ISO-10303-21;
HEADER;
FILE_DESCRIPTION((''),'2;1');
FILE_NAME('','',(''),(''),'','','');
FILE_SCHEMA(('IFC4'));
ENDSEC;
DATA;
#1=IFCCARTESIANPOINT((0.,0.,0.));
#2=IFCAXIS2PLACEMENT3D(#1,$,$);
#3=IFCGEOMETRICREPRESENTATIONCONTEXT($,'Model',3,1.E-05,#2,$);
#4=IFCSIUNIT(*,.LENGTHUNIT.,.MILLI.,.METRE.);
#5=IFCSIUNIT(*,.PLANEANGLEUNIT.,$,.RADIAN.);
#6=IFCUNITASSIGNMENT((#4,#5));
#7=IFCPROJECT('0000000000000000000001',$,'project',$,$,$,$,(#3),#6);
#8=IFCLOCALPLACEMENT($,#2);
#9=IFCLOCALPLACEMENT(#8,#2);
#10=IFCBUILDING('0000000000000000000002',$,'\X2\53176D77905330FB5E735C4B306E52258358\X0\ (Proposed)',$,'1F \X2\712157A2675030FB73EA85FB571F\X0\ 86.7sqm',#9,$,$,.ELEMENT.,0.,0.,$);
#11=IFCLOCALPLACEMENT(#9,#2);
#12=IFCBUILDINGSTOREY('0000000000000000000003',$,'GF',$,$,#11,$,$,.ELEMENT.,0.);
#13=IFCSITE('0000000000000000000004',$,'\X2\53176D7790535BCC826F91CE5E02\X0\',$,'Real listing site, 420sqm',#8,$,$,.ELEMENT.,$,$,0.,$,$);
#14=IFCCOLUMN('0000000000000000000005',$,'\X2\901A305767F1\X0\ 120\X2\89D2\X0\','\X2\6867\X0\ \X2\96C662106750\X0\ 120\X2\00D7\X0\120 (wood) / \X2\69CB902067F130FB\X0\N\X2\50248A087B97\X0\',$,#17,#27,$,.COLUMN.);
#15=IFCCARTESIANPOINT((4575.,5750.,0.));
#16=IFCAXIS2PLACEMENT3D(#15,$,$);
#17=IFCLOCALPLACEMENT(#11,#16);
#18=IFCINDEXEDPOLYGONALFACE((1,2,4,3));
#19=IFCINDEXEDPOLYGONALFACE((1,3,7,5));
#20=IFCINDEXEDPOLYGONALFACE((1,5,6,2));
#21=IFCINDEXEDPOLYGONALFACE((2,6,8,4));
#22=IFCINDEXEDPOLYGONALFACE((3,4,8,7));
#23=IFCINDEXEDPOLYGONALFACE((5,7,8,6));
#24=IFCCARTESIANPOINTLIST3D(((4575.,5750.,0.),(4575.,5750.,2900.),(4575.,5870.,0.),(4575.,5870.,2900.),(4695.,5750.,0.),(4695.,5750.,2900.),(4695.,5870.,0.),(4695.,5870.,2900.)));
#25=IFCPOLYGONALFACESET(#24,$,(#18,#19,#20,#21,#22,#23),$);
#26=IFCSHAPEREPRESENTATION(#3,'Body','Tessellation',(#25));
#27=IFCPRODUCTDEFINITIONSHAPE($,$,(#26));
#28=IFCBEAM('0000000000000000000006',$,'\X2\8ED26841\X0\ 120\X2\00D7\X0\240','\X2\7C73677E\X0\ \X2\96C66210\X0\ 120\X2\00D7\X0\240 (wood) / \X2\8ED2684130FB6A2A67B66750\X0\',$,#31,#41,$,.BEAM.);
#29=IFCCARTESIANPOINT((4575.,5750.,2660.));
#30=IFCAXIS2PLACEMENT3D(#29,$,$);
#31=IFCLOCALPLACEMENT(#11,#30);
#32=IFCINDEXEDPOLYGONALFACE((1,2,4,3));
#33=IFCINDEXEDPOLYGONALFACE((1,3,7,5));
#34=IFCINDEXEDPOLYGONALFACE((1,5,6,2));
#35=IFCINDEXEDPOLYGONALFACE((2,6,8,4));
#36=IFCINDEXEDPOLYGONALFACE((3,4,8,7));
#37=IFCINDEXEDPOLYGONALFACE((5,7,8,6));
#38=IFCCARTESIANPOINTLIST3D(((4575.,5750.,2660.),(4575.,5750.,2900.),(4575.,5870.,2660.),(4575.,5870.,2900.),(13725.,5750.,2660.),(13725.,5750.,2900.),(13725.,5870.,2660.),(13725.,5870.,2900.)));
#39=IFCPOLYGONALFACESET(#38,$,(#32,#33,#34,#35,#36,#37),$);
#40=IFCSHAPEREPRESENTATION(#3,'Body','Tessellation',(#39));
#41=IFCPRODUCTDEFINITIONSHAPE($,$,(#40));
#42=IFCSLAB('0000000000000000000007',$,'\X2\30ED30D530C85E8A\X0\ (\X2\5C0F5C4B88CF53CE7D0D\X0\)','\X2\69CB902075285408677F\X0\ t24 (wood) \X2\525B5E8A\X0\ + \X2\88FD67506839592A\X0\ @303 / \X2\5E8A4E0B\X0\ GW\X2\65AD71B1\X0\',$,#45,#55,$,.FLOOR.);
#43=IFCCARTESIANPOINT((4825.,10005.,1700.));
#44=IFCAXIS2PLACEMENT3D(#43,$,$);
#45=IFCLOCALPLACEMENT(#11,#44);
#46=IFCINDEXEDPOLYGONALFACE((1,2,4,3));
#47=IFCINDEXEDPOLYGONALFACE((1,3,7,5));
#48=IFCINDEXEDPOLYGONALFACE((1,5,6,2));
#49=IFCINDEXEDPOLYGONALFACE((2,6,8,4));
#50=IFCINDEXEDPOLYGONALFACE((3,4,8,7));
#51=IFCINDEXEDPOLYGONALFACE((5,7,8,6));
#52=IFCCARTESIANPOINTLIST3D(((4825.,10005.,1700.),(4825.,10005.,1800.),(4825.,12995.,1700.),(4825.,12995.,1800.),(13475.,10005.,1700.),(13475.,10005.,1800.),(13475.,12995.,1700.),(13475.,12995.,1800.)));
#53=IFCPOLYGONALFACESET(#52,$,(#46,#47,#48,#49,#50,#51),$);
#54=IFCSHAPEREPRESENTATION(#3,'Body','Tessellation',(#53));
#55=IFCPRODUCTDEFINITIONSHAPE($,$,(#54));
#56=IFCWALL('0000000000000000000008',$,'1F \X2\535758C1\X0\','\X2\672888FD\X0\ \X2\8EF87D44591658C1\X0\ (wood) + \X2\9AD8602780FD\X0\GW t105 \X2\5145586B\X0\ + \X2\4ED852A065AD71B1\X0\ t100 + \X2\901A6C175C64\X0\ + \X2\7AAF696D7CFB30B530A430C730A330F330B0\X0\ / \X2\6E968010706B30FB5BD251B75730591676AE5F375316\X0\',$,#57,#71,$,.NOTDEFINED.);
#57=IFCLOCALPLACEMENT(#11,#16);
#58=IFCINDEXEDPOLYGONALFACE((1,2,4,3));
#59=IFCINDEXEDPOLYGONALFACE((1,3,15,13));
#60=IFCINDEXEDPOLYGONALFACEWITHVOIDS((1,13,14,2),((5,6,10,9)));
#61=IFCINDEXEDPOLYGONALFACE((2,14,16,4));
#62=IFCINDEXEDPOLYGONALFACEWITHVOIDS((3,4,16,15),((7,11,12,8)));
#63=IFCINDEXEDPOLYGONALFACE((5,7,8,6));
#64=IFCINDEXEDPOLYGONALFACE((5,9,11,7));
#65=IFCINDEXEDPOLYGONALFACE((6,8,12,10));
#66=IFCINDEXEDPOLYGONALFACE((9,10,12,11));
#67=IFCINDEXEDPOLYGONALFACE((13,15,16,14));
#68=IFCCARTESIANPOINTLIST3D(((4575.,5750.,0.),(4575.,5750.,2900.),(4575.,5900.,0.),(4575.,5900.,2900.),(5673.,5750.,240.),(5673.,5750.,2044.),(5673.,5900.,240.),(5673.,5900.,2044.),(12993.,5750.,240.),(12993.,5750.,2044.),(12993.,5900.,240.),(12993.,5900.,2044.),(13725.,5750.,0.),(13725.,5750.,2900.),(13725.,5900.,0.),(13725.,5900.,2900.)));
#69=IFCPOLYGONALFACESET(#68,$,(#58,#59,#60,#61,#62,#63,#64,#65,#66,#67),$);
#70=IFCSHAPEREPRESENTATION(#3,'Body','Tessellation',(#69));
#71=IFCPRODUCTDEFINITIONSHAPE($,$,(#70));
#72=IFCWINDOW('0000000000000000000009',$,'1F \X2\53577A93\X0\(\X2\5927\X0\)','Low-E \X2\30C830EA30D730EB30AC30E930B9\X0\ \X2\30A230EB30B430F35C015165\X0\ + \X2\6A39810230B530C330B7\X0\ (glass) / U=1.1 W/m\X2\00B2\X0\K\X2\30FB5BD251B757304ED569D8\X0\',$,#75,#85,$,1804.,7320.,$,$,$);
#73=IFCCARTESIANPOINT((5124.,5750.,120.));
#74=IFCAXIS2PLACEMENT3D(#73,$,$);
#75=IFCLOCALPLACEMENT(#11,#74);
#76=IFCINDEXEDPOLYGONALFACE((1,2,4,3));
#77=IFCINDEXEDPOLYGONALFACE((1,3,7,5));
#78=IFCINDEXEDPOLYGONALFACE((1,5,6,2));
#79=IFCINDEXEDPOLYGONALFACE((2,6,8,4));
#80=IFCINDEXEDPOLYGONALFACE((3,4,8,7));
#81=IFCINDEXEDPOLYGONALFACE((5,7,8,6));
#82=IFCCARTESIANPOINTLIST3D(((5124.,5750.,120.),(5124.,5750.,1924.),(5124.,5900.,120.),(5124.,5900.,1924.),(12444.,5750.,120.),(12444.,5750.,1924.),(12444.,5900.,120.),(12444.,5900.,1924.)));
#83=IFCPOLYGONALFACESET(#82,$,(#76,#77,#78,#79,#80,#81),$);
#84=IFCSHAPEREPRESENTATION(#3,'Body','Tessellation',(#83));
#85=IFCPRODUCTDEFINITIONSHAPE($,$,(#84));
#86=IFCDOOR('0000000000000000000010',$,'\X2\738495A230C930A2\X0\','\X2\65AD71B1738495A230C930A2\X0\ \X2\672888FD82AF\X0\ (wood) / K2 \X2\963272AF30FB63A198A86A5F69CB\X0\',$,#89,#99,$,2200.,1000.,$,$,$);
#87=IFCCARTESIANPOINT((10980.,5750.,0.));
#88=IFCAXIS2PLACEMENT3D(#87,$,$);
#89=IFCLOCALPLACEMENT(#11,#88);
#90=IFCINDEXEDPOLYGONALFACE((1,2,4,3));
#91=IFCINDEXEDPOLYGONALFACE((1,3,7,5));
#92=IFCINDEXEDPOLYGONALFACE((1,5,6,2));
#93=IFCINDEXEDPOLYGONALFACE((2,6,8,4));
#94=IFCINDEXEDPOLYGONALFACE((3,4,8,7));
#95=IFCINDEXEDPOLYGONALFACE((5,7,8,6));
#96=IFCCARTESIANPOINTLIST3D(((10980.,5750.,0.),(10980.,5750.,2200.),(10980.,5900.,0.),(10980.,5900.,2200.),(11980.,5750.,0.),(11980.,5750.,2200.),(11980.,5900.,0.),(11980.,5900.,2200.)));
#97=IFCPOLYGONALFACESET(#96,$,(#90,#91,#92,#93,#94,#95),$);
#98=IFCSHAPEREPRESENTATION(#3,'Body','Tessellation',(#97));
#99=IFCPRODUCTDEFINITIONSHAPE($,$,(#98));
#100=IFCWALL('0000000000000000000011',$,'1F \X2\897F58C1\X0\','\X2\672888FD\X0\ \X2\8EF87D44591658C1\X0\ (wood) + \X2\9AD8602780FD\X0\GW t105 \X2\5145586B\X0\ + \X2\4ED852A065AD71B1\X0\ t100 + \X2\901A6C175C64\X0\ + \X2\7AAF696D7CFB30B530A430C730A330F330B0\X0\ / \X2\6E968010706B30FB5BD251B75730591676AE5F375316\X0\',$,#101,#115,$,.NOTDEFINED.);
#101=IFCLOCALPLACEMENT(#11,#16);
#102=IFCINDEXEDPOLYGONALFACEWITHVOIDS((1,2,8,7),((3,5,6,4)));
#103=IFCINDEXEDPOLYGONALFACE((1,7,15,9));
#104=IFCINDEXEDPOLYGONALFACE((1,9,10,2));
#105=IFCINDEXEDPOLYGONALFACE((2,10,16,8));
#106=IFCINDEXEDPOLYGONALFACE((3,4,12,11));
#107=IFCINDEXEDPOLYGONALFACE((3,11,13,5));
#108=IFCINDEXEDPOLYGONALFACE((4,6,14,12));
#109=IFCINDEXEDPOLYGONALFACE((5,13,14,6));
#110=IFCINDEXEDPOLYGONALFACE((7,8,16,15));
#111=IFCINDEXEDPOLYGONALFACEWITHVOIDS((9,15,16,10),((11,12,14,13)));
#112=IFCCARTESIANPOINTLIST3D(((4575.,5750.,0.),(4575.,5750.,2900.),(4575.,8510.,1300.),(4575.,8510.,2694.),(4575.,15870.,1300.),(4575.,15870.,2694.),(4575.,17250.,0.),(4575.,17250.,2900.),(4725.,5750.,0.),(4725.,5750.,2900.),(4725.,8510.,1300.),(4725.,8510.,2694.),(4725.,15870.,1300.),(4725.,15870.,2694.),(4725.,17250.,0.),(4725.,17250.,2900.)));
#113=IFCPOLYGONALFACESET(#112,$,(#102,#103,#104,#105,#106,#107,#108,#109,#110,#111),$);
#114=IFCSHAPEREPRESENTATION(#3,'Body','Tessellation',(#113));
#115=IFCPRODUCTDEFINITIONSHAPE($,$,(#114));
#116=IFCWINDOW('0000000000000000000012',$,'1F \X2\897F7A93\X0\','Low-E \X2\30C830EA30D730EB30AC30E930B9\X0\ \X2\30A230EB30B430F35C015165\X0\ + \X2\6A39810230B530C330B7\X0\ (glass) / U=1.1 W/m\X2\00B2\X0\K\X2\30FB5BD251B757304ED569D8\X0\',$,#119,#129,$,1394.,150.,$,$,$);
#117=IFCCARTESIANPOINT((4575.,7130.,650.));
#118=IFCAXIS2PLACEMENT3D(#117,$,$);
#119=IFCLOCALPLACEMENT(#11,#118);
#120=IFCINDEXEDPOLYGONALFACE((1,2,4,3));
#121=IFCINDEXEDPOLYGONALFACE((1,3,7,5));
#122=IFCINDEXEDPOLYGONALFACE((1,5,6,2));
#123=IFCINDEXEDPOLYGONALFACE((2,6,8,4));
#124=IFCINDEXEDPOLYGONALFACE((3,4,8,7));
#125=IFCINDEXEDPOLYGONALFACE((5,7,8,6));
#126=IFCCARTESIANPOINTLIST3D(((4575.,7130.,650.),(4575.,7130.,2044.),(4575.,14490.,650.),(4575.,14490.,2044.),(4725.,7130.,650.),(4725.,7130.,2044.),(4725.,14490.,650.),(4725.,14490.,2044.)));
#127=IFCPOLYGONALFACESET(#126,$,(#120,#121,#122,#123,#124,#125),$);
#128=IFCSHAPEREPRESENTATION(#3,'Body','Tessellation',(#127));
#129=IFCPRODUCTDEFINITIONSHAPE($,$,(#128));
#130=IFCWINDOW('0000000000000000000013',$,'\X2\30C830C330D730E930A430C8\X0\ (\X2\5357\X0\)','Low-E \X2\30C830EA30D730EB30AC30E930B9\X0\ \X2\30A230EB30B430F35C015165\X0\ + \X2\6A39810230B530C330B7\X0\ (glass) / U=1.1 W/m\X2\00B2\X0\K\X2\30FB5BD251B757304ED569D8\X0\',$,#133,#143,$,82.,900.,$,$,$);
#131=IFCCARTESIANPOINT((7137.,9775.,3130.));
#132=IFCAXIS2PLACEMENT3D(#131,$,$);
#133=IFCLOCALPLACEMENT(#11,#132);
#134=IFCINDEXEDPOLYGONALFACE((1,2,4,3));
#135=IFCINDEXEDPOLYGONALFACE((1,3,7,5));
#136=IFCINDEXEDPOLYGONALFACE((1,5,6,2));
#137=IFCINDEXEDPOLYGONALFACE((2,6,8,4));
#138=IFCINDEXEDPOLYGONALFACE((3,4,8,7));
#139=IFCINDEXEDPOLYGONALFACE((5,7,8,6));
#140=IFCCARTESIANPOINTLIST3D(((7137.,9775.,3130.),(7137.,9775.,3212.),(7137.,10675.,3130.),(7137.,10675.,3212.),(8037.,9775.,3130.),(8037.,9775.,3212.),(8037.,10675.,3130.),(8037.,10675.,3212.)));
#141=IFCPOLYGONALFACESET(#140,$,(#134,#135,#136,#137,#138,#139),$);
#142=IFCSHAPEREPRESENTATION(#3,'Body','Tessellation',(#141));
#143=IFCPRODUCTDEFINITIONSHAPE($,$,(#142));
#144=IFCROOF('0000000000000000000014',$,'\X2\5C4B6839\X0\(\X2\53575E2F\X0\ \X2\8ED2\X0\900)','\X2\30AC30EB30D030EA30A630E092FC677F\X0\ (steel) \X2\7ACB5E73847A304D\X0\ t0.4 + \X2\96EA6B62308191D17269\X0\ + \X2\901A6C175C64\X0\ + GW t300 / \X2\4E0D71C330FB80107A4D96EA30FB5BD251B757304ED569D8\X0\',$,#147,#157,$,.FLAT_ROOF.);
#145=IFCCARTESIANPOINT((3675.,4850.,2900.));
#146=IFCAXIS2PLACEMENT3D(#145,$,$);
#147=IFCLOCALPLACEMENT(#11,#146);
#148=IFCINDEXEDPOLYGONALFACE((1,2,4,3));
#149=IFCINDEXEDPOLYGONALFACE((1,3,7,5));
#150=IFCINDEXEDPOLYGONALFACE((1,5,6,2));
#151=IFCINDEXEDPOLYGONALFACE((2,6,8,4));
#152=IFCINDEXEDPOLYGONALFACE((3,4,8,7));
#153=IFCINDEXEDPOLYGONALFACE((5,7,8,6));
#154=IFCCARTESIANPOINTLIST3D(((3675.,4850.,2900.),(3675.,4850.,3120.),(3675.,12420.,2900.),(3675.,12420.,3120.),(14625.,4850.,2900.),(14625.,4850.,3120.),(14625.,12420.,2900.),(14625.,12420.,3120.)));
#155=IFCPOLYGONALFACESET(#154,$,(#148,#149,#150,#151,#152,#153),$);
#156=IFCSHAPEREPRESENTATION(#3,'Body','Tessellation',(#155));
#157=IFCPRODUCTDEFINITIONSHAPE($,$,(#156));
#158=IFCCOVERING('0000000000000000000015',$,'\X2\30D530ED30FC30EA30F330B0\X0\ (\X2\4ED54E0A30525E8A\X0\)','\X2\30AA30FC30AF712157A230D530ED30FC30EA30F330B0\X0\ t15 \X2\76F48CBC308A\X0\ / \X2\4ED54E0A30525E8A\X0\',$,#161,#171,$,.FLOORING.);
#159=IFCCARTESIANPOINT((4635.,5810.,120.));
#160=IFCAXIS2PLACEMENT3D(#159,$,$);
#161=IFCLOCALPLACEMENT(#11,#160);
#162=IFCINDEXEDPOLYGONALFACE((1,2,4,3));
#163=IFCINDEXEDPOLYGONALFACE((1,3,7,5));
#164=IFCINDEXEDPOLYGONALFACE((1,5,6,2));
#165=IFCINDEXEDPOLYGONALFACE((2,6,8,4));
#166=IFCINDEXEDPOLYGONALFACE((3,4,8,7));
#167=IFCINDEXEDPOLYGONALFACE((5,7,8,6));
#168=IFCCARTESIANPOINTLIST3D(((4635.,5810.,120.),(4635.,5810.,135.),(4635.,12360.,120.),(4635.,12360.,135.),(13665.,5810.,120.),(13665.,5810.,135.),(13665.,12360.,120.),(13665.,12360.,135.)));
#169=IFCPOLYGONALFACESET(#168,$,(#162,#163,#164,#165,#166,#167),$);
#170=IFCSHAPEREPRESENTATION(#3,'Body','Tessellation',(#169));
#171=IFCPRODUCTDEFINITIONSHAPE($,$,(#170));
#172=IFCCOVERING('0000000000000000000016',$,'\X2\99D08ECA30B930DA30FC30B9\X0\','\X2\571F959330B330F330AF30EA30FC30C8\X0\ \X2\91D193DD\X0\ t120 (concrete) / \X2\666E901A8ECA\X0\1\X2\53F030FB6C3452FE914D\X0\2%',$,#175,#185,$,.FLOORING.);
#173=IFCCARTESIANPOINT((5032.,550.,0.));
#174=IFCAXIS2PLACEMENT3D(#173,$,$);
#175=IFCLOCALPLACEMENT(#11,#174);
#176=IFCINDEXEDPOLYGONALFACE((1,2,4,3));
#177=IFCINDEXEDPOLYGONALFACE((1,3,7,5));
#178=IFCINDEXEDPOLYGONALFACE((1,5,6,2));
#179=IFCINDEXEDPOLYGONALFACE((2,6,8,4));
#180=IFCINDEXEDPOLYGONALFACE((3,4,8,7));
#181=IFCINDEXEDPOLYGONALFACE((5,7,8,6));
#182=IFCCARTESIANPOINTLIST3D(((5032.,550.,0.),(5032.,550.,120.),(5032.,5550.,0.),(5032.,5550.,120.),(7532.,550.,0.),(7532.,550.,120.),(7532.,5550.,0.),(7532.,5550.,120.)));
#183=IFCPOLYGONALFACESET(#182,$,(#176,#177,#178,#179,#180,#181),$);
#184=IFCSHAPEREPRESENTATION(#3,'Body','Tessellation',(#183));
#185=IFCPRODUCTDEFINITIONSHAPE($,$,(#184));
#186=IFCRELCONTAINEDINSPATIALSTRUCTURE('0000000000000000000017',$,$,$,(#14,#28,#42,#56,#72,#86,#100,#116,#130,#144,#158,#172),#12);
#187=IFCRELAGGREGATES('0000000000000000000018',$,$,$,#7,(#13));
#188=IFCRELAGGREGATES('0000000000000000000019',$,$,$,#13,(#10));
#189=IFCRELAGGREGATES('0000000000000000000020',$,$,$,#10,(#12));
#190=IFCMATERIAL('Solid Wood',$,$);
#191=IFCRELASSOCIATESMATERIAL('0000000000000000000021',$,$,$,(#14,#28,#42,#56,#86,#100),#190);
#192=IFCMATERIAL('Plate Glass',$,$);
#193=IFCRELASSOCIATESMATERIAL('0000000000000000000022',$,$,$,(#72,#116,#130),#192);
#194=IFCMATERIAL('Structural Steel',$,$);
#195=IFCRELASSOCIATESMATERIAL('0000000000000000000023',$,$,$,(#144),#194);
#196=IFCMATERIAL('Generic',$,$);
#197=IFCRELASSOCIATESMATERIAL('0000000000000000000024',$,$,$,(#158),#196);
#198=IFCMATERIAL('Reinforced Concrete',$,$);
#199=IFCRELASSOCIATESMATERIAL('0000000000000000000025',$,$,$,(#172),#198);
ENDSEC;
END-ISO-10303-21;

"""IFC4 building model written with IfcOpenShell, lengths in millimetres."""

from ifc_helpers import new_model, si_unit, frame, frame_2d, origin, place, context, project, spatial, rectangle, extrude, material, element, fill, save


model = new_model("IFC4")

# Units and contexts
model_context = context("Model", 3, precision=1e-05, world=origin())
ifc_project = project(units=[si_unit("LENGTHUNIT", "METRE", prefix="MILLI"), si_unit("PLANEANGLEUNIT", "RADIAN")], contexts=[model_context])

# Site, building, storey
site_placement = place(None, origin())
site = spatial("IfcSite", under=ifc_project, at=site_placement, Name="北海道富良野市", ObjectType="Real listing site, 420sqm", CompositionType="ELEMENT", RefElevation=0.0)
building_placement = place(site_placement, origin())
building = spatial("IfcBuilding", under=site, at=building_placement, Name="北海道・平屋の別荘 (Proposed)", ObjectType="1F 無垢材・珪藻土 86.7sqm", CompositionType="ELEMENT", ElevationOfRefHeight=0.0, ElevationOfTerrain=0.0)
storey_placement = place(building_placement, origin())
storey = spatial("IfcBuildingStorey", under=building, at=storey_placement, Name="GF", CompositionType="ELEMENT", Elevation=0.0)

# Column
ifc_material_1 = material(Name="Solid Wood")
column_1_placement = place(storey_placement, frame((4575.0, 5750.0, 0.0)))
element("IfcColumn", 1, at=column_1_placement, inside=storey, material=ifc_material_1, Name="通し柱 120角", Description="桧 集成材 120×120 (wood) / 構造柱・N値計算", PredefinedType="COLUMN", context=model_context, shape_type="SweptSolid", body=[
    extrude(rectangle(XDim=120.0, YDim=120.0, at=frame_2d((60.0, 60.0))), frame((4575.0, 5750.0, 0.0)), (0.0, 0.0, 1.0), 2900.0),
])

# Beam
beam_1_placement = place(storey_placement, frame((4575.0, 5750.0, 2660.0)))
element("IfcBeam", 2, at=beam_1_placement, inside=storey, material=ifc_material_1, Name="軒桁 120×240", Description="米松 集成 120×240 (wood) / 軒桁・横架材", PredefinedType="BEAM", context=model_context, shape_type="SweptSolid", body=[
    extrude(rectangle(XDim=9150.0, YDim=120.0, at=frame_2d((4575.0, 60.0))), frame((4575.0, 5750.0, 2660.0)), (0.0, 0.0, 1.0), 240.0),
])

# Slab
ifc_material_2 = material(Name="Reinforced Concrete")
slab_1_placement = place(storey_placement, frame((4825.0, 10005.0, 1700.0)))
element("IfcSlab", 3, at=slab_1_placement, inside=storey, material=ifc_material_1, Name="ロフト床 (小屋裏収納)", Description="構造用合板 t24 (wood) 剛床 + 製材根太 @303 / 床下 GW断熱", PredefinedType="FLOOR", context=model_context, shape_type="SweptSolid", body=[
    extrude(rectangle(XDim=8650.0, YDim=2990.0, at=frame_2d((4325.0, 1495.0))), frame((4825.0, 10005.0, 1700.0)), (0.0, 0.0, 1.0), 100.0),
])

# Wall, openings, window, door
wall_1_placement = place(storey_placement, frame((4575.0, 5750.0, 0.0)))
wall_1 = element("IfcWall", 4, at=wall_1_placement, inside=storey, material=ifc_material_1, Name="1F 南壁", Description="木製 軸組外壁 (wood) + 高性能GW t105 充填 + 付加断熱 t100 + 通気層 + 窯業系サイディング / 準耐火・寒冷地外皮強化", PredefinedType="NOTDEFINED", context=model_context, shape_type="SweptSolid", body=[
    extrude(rectangle(XDim=9150.0, YDim=150.0, at=frame_2d((4575.0, 75.0))), frame((4575.0, 5750.0, 0.0)), (0.0, 0.0, 1.0), 2900.0),
])
opening_1_placement = place(storey_placement, frame((5124.0, 5750.0, 120.0)))
opening_1 = element("IfcOpeningElement", 5, at=opening_1_placement, cuts=wall_1, PredefinedType="NOTDEFINED", context=model_context, shape_type="SweptSolid", body=[
    extrude(rectangle(XDim=7320.0, YDim=150.0, at=frame_2d((3660.0, 75.0))), frame((5124.0, 5750.0, 120.0)), (0.0, 0.0, 1.0), 1804.0),
])
opening_2_placement = place(storey_placement, frame((10980.0, 5750.0, 0.0)))
opening_2 = element("IfcOpeningElement", 6, at=opening_2_placement, cuts=wall_1, PredefinedType="NOTDEFINED", context=model_context, shape_type="SweptSolid", body=[
    extrude(rectangle(XDim=1000.0, YDim=150.0, at=frame_2d((500.0, 75.0))), frame((10980.0, 5750.0, 0.0)), (0.0, 0.0, 1.0), 2200.0),
])
ifc_material_3 = material(Name="Plate Glass")
window_1_placement = place(storey_placement, frame((5124.0, 5750.0, 120.0)))
window_1 = element("IfcWindow", 7, at=window_1_placement, inside=storey, material=ifc_material_3, Name="1F 南窓(大)", Description="Low-E トリプルガラス アルゴン封入 + 樹脂サッシ (glass) / U=1.1 W/m²K・寒冷地仕様", OverallHeight=1804.0, OverallWidth=7320.0, context=model_context, shape_type="SweptSolid", body=[
    extrude(rectangle(XDim=7320.0, YDim=150.0, at=frame_2d((3660.0, 75.0))), frame((5124.0, 5750.0, 120.0)), (0.0, 0.0, 1.0), 1804.0),
])
fill(opening_1, window_1)
door_1_placement = place(storey_placement, frame((10980.0, 5750.0, 0.0)))
door_1 = element("IfcDoor", 8, at=door_1_placement, inside=storey, material=ifc_material_1, Name="玄関ドア", Description="断熱玄関ドア 木製芯 (wood) / K2 防犯・採風機構", OverallHeight=2200.0, OverallWidth=1000.0, context=model_context, shape_type="SweptSolid", body=[
    extrude(rectangle(XDim=1000.0, YDim=150.0, at=frame_2d((500.0, 75.0))), frame((10980.0, 5750.0, 0.0)), (0.0, 0.0, 1.0), 2200.0),
])
fill(opening_2, door_1)

# Wall, opening, window
wall_2_placement = place(storey_placement, frame((4575.0, 5750.0, 0.0)))
wall_2 = element("IfcWall", 9, at=wall_2_placement, inside=storey, material=ifc_material_1, Name="1F 西壁", Description="木製 軸組外壁 (wood) + 高性能GW t105 充填 + 付加断熱 t100 + 通気層 + 窯業系サイディング / 準耐火・寒冷地外皮強化", PredefinedType="NOTDEFINED", context=model_context, shape_type="SweptSolid", body=[
    extrude(rectangle(XDim=150.0, YDim=11500.0, at=frame_2d((75.0, 5750.0))), frame((4575.0, 5750.0, 0.0)), (0.0, 0.0, 1.0), 2900.0),
])
opening_3_placement = place(storey_placement, frame((4575.0, 7130.0, 650.0)))
opening_3 = element("IfcOpeningElement", 10, at=opening_3_placement, cuts=wall_2, PredefinedType="NOTDEFINED", context=model_context, shape_type="SweptSolid", body=[
    extrude(rectangle(XDim=150.0, YDim=7360.0, at=frame_2d((75.0, 3680.0))), frame((4575.0, 7130.0, 650.0)), (0.0, 0.0, 1.0), 1394.0),
])
window_2_placement = place(storey_placement, frame((4575.0, 7130.0, 650.0)))
window_2 = element("IfcWindow", 11, at=window_2_placement, inside=storey, material=ifc_material_3, Name="1F 西窓", Description="Low-E トリプルガラス アルゴン封入 + 樹脂サッシ (glass) / U=1.1 W/m²K・寒冷地仕様", OverallHeight=1394.0, OverallWidth=150.0, context=model_context, shape_type="SweptSolid", body=[
    extrude(rectangle(XDim=150.0, YDim=7360.0, at=frame_2d((75.0, 3680.0))), frame((4575.0, 7130.0, 650.0)), (0.0, 0.0, 1.0), 1394.0),
])
fill(opening_3, window_2)

# Window
window_3_placement = place(storey_placement, frame((7137.0, 9775.0, 3130.0)))
element("IfcWindow", 12, at=window_3_placement, inside=storey, material=ifc_material_3, Name="トップライト (南)", Description="Low-E トリプルガラス アルゴン封入 + 樹脂サッシ (glass) / U=1.1 W/m²K・寒冷地仕様", OverallHeight=82.0, OverallWidth=900.0, context=model_context, shape_type="SweptSolid", body=[
    extrude(rectangle(XDim=900.0, YDim=900.0, at=frame_2d((450.0, 450.0))), frame((7137.0, 9775.0, 3130.0)), (0.0, 0.0, 1.0), 82.0),
])

# Roof
ifc_material_4 = material(Name="Structural Steel")
roof_placement = place(storey_placement, frame((3675.0, 4850.0, 2900.0)))
element("IfcRoof", 13, at=roof_placement, inside=storey, material=ifc_material_4, Name="屋根(南帯 軒900)", Description="ガルバリウム鋼板 (steel) 立平葺き t0.4 + 雪止め金物 + 通気層 + GW t300 / 不燃・耐積雪・寒冷地仕様", PredefinedType="FLAT_ROOF", context=model_context, shape_type="SweptSolid", body=[
    extrude(rectangle(XDim=10950.0, YDim=7570.0, at=frame_2d((5475.0, 3785.0))), frame((3675.0, 4850.0, 2900.0)), (0.0, 0.0, 1.0), 220.0),
])

# Coverings
ifc_material_5 = material(Name="Generic")
covering_1_placement = place(storey_placement, frame((4635.0, 5810.0, 120.0)))
element("IfcCovering", 14, at=covering_1_placement, inside=storey, material=ifc_material_5, Name="フローリング (仕上げ床)", Description="オーク無垢フローリング t15 直貼り / 仕上げ床", PredefinedType="FLOORING", context=model_context, shape_type="SweptSolid", body=[
    extrude(rectangle(XDim=9030.0, YDim=6550.0, at=frame_2d((4515.0, 3275.0))), frame((4635.0, 5810.0, 120.0)), (0.0, 0.0, 1.0), 15.0),
])
covering_2_placement = place(storey_placement, frame((5032.0, 550.0, 0.0)))
element("IfcCovering", 15, at=covering_2_placement, inside=storey, material=ifc_material_2, Name="駐車スペース", Description="土間コンクリート 金鏝 t120 (concrete) / 普通車1台・水勾配2%", PredefinedType="FLOORING", context=model_context, shape_type="SweptSolid", body=[
    extrude(rectangle(XDim=2500.0, YDim=5000.0, at=frame_2d((1250.0, 2500.0))), frame((5032.0, 550.0, 0.0)), (0.0, 0.0, 1.0), 120.0),
])

save(model, "model.ifc")
